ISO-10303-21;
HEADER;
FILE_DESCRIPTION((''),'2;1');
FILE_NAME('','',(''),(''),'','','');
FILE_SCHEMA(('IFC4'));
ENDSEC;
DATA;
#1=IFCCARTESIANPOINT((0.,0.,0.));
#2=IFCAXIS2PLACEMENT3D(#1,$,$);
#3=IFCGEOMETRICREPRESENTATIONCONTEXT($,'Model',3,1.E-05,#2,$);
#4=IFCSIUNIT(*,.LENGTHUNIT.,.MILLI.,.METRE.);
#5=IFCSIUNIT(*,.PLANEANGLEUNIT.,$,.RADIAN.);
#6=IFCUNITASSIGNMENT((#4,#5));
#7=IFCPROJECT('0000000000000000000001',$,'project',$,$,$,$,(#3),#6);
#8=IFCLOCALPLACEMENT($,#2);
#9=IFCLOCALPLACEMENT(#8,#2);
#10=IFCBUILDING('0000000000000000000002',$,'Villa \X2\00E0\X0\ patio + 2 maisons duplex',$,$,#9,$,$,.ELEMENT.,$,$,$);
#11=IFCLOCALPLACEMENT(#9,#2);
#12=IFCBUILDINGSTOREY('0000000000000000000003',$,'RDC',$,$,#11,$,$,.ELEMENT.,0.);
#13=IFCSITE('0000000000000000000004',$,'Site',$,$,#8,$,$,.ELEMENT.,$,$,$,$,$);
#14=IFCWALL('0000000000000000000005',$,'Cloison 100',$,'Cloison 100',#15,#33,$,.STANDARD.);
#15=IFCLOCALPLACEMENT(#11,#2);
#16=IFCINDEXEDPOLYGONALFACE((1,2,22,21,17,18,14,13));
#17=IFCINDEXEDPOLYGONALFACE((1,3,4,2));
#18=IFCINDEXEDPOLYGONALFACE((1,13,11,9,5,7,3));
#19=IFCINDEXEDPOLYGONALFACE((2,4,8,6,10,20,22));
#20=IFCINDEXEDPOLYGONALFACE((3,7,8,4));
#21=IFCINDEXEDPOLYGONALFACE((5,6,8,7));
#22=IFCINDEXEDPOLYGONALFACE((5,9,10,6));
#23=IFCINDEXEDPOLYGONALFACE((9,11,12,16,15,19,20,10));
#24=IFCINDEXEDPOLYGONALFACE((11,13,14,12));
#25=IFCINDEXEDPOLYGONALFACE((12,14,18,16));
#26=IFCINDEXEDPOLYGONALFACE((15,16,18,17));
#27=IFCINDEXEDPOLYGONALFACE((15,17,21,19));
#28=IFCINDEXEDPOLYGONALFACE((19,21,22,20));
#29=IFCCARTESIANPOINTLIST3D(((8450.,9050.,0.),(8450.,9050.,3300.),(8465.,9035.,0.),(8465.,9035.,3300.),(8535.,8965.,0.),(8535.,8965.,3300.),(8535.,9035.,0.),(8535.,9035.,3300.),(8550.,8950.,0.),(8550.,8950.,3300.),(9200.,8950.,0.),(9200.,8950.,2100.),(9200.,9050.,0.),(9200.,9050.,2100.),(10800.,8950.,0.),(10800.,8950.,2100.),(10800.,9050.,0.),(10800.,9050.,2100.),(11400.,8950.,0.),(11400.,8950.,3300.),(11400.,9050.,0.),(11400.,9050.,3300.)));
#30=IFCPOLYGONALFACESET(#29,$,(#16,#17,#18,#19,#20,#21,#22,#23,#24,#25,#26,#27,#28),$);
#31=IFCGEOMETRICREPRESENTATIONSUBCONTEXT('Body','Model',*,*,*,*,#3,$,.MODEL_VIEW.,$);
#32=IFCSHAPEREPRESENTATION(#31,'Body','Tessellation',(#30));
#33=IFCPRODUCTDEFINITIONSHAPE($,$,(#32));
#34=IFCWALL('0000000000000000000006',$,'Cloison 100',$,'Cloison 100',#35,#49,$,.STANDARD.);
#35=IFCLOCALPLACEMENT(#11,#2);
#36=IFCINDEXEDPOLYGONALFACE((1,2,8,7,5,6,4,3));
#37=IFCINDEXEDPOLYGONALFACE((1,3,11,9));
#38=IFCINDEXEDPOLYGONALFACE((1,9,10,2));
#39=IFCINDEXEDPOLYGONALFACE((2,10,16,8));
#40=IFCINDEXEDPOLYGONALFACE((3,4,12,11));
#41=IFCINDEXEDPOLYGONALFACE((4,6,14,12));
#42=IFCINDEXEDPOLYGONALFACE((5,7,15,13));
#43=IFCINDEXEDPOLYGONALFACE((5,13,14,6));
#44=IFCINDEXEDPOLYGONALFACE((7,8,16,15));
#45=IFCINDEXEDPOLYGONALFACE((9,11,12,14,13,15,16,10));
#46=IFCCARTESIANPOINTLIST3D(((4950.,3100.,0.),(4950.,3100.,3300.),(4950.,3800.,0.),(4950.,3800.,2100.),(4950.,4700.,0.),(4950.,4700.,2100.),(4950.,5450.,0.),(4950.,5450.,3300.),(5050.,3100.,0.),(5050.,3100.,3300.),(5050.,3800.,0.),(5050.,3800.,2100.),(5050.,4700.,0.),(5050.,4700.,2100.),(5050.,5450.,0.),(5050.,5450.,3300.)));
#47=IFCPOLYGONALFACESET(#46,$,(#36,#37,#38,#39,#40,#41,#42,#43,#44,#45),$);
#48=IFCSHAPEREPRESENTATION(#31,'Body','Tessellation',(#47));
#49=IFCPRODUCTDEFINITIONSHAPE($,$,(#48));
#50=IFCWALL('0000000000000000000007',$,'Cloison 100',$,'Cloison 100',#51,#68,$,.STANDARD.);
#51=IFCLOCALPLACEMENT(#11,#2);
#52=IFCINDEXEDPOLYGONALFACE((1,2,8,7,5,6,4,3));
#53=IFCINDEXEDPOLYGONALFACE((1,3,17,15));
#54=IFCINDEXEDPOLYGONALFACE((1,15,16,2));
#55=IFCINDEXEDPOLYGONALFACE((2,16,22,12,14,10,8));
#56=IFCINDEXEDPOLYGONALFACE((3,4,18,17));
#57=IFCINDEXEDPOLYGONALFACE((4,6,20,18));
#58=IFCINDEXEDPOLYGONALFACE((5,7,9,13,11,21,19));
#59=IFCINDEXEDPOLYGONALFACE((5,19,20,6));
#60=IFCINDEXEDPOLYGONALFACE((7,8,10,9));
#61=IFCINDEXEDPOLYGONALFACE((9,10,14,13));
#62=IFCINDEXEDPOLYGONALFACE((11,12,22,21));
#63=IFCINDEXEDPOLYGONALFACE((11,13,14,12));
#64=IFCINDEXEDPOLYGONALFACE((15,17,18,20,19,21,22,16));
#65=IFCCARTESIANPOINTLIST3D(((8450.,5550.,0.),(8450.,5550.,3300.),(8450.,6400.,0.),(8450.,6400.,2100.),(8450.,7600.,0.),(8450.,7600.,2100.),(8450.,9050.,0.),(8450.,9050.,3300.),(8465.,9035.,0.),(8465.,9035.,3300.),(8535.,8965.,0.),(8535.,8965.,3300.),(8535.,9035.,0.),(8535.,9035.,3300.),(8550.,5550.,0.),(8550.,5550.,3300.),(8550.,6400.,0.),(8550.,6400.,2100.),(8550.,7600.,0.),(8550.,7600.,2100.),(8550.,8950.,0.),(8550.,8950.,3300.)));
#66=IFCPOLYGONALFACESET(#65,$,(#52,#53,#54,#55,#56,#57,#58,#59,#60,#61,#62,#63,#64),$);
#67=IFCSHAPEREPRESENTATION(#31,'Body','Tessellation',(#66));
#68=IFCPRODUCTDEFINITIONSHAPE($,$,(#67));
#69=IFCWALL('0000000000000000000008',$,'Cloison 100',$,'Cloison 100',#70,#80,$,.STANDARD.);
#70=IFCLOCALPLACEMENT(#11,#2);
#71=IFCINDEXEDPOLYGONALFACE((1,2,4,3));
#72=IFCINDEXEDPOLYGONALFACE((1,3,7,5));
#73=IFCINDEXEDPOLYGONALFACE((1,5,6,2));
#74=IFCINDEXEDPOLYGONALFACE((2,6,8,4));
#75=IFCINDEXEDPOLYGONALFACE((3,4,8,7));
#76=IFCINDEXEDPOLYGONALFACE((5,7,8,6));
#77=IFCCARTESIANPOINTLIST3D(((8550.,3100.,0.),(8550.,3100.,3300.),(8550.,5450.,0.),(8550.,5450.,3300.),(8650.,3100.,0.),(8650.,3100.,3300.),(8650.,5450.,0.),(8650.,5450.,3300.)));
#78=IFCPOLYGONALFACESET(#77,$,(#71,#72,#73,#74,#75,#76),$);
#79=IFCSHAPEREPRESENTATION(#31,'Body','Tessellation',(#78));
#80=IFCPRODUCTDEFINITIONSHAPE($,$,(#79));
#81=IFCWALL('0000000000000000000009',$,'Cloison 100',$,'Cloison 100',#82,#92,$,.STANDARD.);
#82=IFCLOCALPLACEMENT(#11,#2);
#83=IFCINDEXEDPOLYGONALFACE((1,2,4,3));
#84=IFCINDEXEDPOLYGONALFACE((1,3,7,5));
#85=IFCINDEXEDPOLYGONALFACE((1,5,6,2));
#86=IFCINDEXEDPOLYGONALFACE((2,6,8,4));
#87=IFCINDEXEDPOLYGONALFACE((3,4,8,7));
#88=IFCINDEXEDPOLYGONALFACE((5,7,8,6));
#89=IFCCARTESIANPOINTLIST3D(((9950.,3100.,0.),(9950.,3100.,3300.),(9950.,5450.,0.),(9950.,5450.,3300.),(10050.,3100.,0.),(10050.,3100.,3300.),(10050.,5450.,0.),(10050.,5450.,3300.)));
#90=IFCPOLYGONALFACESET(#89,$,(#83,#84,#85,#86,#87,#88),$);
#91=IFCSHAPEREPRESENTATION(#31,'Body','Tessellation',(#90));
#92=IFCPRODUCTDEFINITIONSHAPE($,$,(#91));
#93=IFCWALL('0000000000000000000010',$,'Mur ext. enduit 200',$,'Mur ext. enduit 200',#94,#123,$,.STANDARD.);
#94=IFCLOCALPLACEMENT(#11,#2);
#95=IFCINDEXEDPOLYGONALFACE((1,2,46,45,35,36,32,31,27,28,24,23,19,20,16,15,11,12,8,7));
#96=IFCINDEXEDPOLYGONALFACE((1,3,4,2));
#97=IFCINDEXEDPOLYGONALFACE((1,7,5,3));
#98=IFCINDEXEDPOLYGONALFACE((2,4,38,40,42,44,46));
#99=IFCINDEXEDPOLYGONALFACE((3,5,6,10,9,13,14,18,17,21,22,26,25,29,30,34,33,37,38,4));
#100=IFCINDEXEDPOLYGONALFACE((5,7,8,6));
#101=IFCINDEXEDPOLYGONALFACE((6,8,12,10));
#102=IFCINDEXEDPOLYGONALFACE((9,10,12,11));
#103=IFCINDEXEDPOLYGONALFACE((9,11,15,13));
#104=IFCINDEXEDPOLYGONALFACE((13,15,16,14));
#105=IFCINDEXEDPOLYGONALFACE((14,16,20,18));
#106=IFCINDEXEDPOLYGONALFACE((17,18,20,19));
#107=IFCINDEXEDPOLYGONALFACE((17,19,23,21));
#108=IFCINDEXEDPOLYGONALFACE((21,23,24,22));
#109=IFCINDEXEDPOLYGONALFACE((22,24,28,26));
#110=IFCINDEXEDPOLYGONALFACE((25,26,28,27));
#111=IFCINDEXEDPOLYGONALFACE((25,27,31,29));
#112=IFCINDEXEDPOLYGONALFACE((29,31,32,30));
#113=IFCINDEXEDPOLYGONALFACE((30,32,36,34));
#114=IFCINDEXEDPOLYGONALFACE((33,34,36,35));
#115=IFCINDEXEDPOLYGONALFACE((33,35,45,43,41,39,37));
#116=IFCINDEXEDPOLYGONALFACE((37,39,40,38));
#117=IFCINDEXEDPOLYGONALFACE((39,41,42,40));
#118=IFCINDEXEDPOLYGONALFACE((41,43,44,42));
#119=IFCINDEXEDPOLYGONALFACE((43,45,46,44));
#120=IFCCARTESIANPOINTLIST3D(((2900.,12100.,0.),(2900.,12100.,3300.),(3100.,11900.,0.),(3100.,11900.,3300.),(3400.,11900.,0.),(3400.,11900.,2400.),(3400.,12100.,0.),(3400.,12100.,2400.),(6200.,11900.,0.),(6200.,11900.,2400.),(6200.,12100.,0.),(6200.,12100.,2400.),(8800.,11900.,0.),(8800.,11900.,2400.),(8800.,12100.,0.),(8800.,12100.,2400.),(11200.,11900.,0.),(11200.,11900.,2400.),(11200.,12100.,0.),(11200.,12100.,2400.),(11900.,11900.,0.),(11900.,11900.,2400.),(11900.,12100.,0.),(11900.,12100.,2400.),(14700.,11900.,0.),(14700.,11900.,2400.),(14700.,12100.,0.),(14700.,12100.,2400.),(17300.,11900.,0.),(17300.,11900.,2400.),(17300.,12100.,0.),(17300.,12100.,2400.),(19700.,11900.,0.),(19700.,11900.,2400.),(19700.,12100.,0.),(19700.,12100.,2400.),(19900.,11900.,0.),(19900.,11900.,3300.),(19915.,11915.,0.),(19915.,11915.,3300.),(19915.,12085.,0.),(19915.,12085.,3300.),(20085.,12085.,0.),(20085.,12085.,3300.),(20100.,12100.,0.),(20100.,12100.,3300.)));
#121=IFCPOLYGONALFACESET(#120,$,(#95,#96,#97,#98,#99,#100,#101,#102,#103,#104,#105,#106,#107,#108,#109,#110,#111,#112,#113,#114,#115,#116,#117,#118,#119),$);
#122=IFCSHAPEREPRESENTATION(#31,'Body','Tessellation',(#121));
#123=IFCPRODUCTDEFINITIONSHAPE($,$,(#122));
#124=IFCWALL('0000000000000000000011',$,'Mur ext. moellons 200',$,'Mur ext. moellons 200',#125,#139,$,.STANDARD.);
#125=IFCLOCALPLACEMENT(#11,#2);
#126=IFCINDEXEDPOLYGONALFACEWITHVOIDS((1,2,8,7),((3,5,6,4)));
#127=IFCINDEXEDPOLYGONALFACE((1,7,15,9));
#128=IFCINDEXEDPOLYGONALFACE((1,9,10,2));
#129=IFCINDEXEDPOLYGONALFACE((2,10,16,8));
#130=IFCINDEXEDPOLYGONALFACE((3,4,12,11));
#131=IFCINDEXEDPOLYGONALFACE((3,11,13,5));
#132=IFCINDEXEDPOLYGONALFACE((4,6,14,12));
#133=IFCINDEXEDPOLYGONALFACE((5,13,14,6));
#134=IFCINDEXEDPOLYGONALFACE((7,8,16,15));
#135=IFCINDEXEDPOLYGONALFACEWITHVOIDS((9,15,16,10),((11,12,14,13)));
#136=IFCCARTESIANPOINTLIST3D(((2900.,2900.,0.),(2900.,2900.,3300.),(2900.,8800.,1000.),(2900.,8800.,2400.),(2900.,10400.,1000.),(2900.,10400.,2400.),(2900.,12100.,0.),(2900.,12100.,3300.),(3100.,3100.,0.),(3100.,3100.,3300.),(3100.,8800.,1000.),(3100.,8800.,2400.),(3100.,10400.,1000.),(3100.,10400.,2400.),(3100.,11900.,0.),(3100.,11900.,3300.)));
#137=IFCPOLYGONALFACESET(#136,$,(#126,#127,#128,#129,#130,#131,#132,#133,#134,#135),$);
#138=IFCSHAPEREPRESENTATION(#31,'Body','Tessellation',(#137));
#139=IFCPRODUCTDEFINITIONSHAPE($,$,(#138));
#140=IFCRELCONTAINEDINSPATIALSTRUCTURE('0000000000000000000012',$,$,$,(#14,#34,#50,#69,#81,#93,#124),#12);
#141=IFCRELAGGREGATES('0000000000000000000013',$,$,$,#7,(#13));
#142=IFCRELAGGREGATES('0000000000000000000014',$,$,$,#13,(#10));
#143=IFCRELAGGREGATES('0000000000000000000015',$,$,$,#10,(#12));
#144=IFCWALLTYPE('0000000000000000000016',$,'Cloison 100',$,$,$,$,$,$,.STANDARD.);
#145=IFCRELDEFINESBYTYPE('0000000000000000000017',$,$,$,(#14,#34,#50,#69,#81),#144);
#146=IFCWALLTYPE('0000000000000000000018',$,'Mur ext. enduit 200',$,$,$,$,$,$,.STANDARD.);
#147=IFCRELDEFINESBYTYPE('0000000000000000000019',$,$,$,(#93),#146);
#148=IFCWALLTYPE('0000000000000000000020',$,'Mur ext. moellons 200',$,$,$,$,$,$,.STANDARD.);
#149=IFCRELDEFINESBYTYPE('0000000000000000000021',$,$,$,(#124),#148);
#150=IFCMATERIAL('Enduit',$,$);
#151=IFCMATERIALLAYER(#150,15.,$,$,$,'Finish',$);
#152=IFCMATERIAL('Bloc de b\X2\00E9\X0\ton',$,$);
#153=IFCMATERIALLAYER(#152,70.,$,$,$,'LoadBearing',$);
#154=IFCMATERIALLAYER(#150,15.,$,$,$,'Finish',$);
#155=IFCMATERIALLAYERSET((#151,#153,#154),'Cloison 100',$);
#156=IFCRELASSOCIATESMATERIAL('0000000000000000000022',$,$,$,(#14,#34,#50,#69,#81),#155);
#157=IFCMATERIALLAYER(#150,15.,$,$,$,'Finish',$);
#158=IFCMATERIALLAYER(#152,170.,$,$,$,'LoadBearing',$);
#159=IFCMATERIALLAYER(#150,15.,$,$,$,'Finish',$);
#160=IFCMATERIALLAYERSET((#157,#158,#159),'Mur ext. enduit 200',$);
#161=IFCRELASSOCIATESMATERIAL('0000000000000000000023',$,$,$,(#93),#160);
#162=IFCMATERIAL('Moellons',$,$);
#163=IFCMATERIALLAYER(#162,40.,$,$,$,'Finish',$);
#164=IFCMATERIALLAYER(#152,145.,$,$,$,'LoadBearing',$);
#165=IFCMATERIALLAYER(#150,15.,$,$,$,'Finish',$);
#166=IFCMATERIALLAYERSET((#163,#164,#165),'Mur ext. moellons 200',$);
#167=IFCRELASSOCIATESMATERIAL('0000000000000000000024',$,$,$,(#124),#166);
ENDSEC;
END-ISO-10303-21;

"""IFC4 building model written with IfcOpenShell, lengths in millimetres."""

from ifc_helpers import new_model, si_unit, frame, frame_2d, origin, place, context, subcontext, project, spatial, polyline, rectangle, outline, extrude, material, layer, layer_set, layer_usage, type_object, element, save


model = new_model("IFC4")

# Units and contexts
model_context = context("Model", 3, precision=1e-05, world=origin())
body_context = subcontext(model_context, "Body", "Model", "MODEL_VIEW")
ifc_project = project(units=[si_unit("LENGTHUNIT", "METRE", prefix="MILLI"), si_unit("PLANEANGLEUNIT", "RADIAN")], contexts=[model_context])

# Site, building, storey
site_placement = place(None, origin())
site = spatial("IfcSite", under=ifc_project, at=site_placement, Name="Site", CompositionType="ELEMENT")
building_placement = place(site_placement, origin())
building = spatial("IfcBuilding", under=site, at=building_placement, Name="Villa à patio + 2 maisons duplex", CompositionType="ELEMENT")
storey_placement = place(building_placement, origin())
storey = spatial("IfcBuildingStorey", under=building, at=storey_placement, Name="RDC", CompositionType="ELEMENT", Elevation=0.0)

# Wall, opening
ifc_material_1 = material(Name="Enduit")
ifc_layer_1 = layer(ifc_material_1, 15.0, Category="Finish")
ifc_material_2 = material(Name="Bloc de béton")
ifc_layer_2 = layer(ifc_material_2, 70.0, Category="LoadBearing")
ifc_layer_3 = layer(ifc_material_1, 15.0, Category="Finish")
ifc_layer_set_1 = layer_set([ifc_layer_1, ifc_layer_2, ifc_layer_3], Name="Cloison 100")
ifc_layer_usage_1 = layer_usage(ifc_layer_set_1, "AXIS2", "NEGATIVE", 50.0)
wall_type_1 = type_object("IfcWallType", Name="Cloison 100", PredefinedType="STANDARD")
wall_1_placement = place(storey_placement, frame((8500.0, 9000.0, 0.0), z_axis=(0.0, 0.0, 1.0), x_axis=(1.0, 0.0, 0.0)))
wall_1 = element("IfcWall", 1, at=wall_1_placement, inside=storey, type_object=wall_type_1, material=ifc_layer_usage_1, Name="Cloison 100", ObjectType="Cloison 100", PredefinedType="STANDARD", context=body_context, shape_type="SweptSolid", body=[
    extrude(outline(polyline([(50.0, -50.0), (35.0, -35.0), (35.0, 35.0), (-35.0, 35.0), (-50.0, 50.0), (2900.0, 50.0), (2900.0, -50.0), (50.0, -50.0)])), origin(), (0.0, 0.0, 1.0), 3300.0),
])
opening_1_placement = place(wall_1_placement, frame((700.0, 0.0, 0.0), z_axis=(0.0, 0.0, 1.0), x_axis=(1.0, 0.0, 0.0)))
element("IfcOpeningElement", 2, at=opening_1_placement, cuts=wall_1, PredefinedType="OPENING", context=body_context, shape_type="SweptSolid", body=[
    extrude(rectangle(XDim=1600.0, YDim=120.0, at=frame_2d((800.0, 0.0))), origin(), (0.0, 0.0, 1.0), 2100.0),
])

# Walls, openings
wall_2_placement = place(storey_placement, frame((5000.0, 5500.0, 0.0), z_axis=(0.0, 0.0, 1.0), x_axis=(0.0, -1.0, 0.0)))
wall_2 = element("IfcWall", 3, at=wall_2_placement, inside=storey, type_object=wall_type_1, material=ifc_layer_usage_1, Name="Cloison 100", ObjectType="Cloison 100", PredefinedType="STANDARD", context=body_context, shape_type="SweptSolid", body=[
    extrude(outline(polyline([(50.0, -50.0), (50.0, 50.0), (2400.0, 50.0), (2400.0, -50.0), (50.0, -50.0)])), origin(), (0.0, 0.0, 1.0), 3300.0),
])
opening_2_placement = place(wall_2_placement, frame((800.0, 0.0, 0.0), z_axis=(0.0, 0.0, 1.0), x_axis=(1.0, 0.0, 0.0)))
element("IfcOpeningElement", 4, at=opening_2_placement, cuts=wall_2, PredefinedType="OPENING", context=body_context, shape_type="SweptSolid", body=[
    extrude(rectangle(XDim=900.0, YDim=120.0, at=frame_2d((450.0, 0.0))), origin(), (0.0, 0.0, 1.0), 2100.0),
])
wall_3_placement = place(storey_placement, frame((8500.0, 9000.0, 0.0), z_axis=(0.0, 0.0, 1.0), x_axis=(0.0, -1.0, 0.0)))
wall_3 = element("IfcWall", 5, at=wall_3_placement, inside=storey, type_object=wall_type_1, material=ifc_layer_usage_1, Name="Cloison 100", ObjectType="Cloison 100", PredefinedType="STANDARD", context=body_context, shape_type="SweptSolid", body=[
    extrude(outline(polyline([(-50.0, -50.0), (-35.0, -35.0), (-35.0, 35.0), (35.0, 35.0), (50.0, 50.0), (3450.0, 50.0), (3450.0, -50.0), (-50.0, -50.0)])), origin(), (0.0, 0.0, 1.0), 3300.0),
])
opening_3_placement = place(wall_3_placement, frame((1400.0, 0.0, 0.0), z_axis=(0.0, 0.0, 1.0), x_axis=(1.0, 0.0, 0.0)))
element("IfcOpeningElement", 6, at=opening_3_placement, cuts=wall_3, PredefinedType="OPENING", context=body_context, shape_type="SweptSolid", body=[
    extrude(rectangle(XDim=1200.0, YDim=120.0, at=frame_2d((600.0, 0.0))), origin(), (0.0, 0.0, 1.0), 2100.0),
])

# Walls
for number, where, z_axis, x_axis, name in (
    (7, (8600.0, 5500.0, 0.0), (0.0, 0.0, 1.0), (0.0, -1.0, 0.0), "Cloison 100"),
    (8, (10000.0, 5500.0, 0.0), (0.0, 0.0, 1.0), (0.0, -1.0, 0.0), "Cloison 100"),
):
    element("IfcWall", number, at=place(storey_placement, frame(where, z_axis=z_axis, x_axis=x_axis)), inside=storey, type_object=wall_type_1, material=ifc_layer_usage_1, Name=name, ObjectType="Cloison 100", PredefinedType="STANDARD", context=body_context, shape_type="SweptSolid", body=[
        extrude(outline(polyline([(50.0, -50.0), (50.0, 50.0), (2400.0, 50.0), (2400.0, -50.0), (50.0, -50.0)])), origin(), (0.0, 0.0, 1.0), 3300.0),
    ])

# Wall, openings
ifc_layer_4 = layer(ifc_material_1, 15.0, Category="Finish")
ifc_layer_5 = layer(ifc_material_2, 170.0, Category="LoadBearing")
ifc_layer_6 = layer(ifc_material_1, 15.0, Category="Finish")
ifc_layer_set_2 = layer_set([ifc_layer_4, ifc_layer_5, ifc_layer_6], Name="Mur ext. enduit 200")
ifc_layer_usage_2 = layer_usage(ifc_layer_set_2, "AXIS2", "NEGATIVE", 100.0)
wall_type_2 = type_object("IfcWallType", Name="Mur ext. enduit 200", PredefinedType="STANDARD")
wall_4_placement = place(storey_placement, frame((3000.0, 12000.0, 0.0), z_axis=(0.0, 0.0, 1.0), x_axis=(1.0, 0.0, 0.0)))
wall_4 = element("IfcWall", 9, at=wall_4_placement, inside=storey, type_object=wall_type_2, material=ifc_layer_usage_2, Name="Mur ext. enduit 200", ObjectType="Mur ext. enduit 200", PredefinedType="STANDARD", context=body_context, shape_type="SweptSolid", body=[
    extrude(outline(polyline([(100.0, -100.0), (0.0, 0.0), (-100.0, 100.0), (17100.0, 100.0), (17085.0, 85.0), (16915.0, 85.0), (16915.0, -85.0), (16900.0, -100.0), (100.0, -100.0)])), origin(), (0.0, 0.0, 1.0), 3300.0),
])
opening_4_placement = place(wall_4_placement, frame((400.0, 0.0, 0.0), z_axis=(0.0, 0.0, 1.0), x_axis=(1.0, 0.0, 0.0)))
element("IfcOpeningElement", 10, at=opening_4_placement, cuts=wall_4, PredefinedType="OPENING", context=body_context, shape_type="SweptSolid", body=[
    extrude(rectangle(XDim=2800.0, YDim=220.0, at=frame_2d((1400.0, 0.0))), origin(), (0.0, 0.0, 1.0), 2400.0),
])
opening_5_placement = place(wall_4_placement, frame((5800.0, 0.0, 0.0), z_axis=(0.0, 0.0, 1.0), x_axis=(1.0, 0.0, 0.0)))
element("IfcOpeningElement", 11, at=opening_5_placement, cuts=wall_4, PredefinedType="OPENING", context=body_context, shape_type="SweptSolid", body=[
    extrude(rectangle(XDim=2400.0, YDim=220.0, at=frame_2d((1200.0, 0.0))), origin(), (0.0, 0.0, 1.0), 2400.0),
])
opening_6_placement = place(wall_4_placement, frame((8900.0, 0.0, 0.0), z_axis=(0.0, 0.0, 1.0), x_axis=(1.0, 0.0, 0.0)))
element("IfcOpeningElement", 12, at=opening_6_placement, cuts=wall_4, PredefinedType="OPENING", context=body_context, shape_type="SweptSolid", body=[
    extrude(rectangle(XDim=2800.0, YDim=220.0, at=frame_2d((1400.0, 0.0))), origin(), (0.0, 0.0, 1.0), 2400.0),
])
opening_7_placement = place(wall_4_placement, frame((14300.0, 0.0, 0.0), z_axis=(0.0, 0.0, 1.0), x_axis=(1.0, 0.0, 0.0)))
element("IfcOpeningElement", 13, at=opening_7_placement, cuts=wall_4, PredefinedType="OPENING", context=body_context, shape_type="SweptSolid", body=[
    extrude(rectangle(XDim=2400.0, YDim=220.0, at=frame_2d((1200.0, 0.0))), origin(), (0.0, 0.0, 1.0), 2400.0),
])

# Wall, opening
ifc_material_3 = material(Name="Moellons")
ifc_layer_7 = layer(ifc_material_3, 40.0, Category="Finish")
ifc_layer_8 = layer(ifc_material_2, 145.0, Category="LoadBearing")
ifc_layer_9 = layer(ifc_material_1, 15.0, Category="Finish")
ifc_layer_set_3 = layer_set([ifc_layer_7, ifc_layer_8, ifc_layer_9], Name="Mur ext. moellons 200")
ifc_layer_usage_3 = layer_usage(ifc_layer_set_3, "AXIS2", "NEGATIVE", 100.0)
wall_type_3 = type_object("IfcWallType", Name="Mur ext. moellons 200", PredefinedType="STANDARD")
wall_5_placement = place(storey_placement, frame((3000.0, 12000.0, 0.0), z_axis=(0.0, 0.0, 1.0), x_axis=(0.0, -1.0, 0.0)))
wall_5 = element("IfcWall", 14, at=wall_5_placement, inside=storey, type_object=wall_type_3, material=ifc_layer_usage_3, Name="Mur ext. moellons 200", ObjectType="Mur ext. moellons 200", PredefinedType="STANDARD", context=body_context, shape_type="SweptSolid", body=[
    extrude(outline(polyline([(-100.0, -100.0), (0.0, 0.0), (100.0, 100.0), (8900.0, 100.0), (9000.0, 0.0), (9100.0, -100.0), (-100.0, -100.0)])), origin(), (0.0, 0.0, 1.0), 3300.0),
])
opening_8_placement = place(wall_5_placement, frame((1600.0, 0.0, 1000.0), z_axis=(0.0, 0.0, 1.0), x_axis=(1.0, 0.0, 0.0)))
element("IfcOpeningElement", 15, at=opening_8_placement, cuts=wall_5, PredefinedType="OPENING", context=body_context, shape_type="SweptSolid", body=[
    extrude(rectangle(XDim=1600.0, YDim=220.0, at=frame_2d((800.0, 0.0))), origin(), (0.0, 0.0, 1.0), 1400.0),
])

save(model, "model.ifc")
